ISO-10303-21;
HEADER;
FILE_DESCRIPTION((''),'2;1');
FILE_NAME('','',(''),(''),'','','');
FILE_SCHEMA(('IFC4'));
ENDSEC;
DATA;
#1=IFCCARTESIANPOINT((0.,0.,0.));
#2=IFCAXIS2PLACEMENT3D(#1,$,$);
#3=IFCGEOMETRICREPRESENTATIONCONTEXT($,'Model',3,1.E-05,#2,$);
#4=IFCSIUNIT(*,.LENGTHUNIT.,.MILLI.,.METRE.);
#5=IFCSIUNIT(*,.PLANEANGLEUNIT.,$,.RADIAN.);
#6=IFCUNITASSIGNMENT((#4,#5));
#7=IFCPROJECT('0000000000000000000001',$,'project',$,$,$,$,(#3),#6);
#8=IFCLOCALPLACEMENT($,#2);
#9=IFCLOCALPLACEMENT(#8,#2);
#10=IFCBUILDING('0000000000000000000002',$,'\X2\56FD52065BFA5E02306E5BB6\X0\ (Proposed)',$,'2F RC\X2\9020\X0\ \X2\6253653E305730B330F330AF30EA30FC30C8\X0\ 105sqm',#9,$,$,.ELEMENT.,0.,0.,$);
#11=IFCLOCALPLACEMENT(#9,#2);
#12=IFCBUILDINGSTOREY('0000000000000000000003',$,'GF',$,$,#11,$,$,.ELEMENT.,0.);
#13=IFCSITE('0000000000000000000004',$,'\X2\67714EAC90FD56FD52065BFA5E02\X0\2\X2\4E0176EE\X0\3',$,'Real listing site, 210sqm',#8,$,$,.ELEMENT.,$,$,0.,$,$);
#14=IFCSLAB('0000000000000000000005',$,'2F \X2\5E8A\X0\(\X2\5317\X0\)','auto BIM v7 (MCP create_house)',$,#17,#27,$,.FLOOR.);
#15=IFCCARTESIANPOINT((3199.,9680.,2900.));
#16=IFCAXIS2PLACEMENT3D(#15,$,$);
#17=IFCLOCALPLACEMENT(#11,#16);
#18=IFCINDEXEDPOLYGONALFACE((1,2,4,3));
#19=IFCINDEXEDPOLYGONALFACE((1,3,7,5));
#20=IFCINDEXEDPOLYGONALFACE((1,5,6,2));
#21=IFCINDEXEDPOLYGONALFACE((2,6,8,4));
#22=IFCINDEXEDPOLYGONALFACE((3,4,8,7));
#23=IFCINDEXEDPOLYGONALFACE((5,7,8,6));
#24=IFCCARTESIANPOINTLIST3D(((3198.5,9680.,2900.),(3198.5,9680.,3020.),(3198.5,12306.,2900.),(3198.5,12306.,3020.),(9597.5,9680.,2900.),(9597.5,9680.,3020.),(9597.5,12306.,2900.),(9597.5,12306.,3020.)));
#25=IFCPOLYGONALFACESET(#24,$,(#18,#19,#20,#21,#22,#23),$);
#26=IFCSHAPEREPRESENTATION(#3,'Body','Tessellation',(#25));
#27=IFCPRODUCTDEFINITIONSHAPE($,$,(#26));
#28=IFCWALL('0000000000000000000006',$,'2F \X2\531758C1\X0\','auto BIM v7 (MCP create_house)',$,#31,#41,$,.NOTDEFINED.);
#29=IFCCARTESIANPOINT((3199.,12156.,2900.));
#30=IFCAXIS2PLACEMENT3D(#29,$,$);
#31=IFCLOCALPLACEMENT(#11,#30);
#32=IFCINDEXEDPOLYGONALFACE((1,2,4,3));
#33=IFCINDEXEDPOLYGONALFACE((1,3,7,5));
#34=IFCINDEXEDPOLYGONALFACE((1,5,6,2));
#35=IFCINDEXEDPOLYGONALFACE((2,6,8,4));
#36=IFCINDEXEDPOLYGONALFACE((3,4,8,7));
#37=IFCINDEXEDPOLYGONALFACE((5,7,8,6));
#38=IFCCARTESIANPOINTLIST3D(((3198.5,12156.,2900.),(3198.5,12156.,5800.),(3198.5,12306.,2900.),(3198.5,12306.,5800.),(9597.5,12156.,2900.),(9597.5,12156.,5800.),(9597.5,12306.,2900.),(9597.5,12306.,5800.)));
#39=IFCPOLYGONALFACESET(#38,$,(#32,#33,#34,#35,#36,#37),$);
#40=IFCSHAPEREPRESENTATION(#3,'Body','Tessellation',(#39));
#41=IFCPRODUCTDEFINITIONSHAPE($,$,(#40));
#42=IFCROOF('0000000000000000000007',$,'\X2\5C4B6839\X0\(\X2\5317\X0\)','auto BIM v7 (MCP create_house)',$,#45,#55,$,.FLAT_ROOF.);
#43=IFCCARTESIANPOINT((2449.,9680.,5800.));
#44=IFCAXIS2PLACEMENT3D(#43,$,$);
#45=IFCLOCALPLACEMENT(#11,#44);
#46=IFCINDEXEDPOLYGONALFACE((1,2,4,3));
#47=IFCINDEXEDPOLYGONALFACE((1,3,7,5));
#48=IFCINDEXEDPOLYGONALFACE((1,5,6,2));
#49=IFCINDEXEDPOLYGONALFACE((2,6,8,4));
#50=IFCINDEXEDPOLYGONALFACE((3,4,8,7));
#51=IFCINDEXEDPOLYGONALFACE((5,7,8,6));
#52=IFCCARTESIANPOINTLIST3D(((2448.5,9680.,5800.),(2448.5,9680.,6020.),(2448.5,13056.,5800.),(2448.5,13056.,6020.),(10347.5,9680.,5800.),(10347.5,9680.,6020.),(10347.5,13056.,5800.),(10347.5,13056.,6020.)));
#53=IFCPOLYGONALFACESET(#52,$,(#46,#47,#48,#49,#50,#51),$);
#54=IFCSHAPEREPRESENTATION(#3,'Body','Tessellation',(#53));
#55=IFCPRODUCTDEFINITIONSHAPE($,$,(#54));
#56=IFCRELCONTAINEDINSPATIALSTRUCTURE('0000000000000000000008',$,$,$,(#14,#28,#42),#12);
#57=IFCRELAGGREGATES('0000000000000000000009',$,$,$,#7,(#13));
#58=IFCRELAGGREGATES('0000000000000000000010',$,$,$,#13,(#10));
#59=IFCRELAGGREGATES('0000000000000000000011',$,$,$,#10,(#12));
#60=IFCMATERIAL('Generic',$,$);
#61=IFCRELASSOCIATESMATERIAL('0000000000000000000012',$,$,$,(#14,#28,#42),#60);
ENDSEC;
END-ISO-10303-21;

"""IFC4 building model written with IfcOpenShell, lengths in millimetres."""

from ifc_helpers import new_model, si_unit, frame, frame_2d, origin, place, context, project, spatial, rectangle, extrude, material, element, save


model = new_model("IFC4")

# Units and contexts
model_context = context("Model", 3, precision=1e-05, world=origin())
ifc_project = project(units=[si_unit("LENGTHUNIT", "METRE", prefix="MILLI"), si_unit("PLANEANGLEUNIT", "RADIAN")], contexts=[model_context])

# Site, building, storey
site_placement = place(None, origin())
site = spatial("IfcSite", under=ifc_project, at=site_placement, Name="東京都国分寺市2丁目3", ObjectType="Real listing site, 210sqm", CompositionType="ELEMENT", RefElevation=0.0)
building_placement = place(site_placement, origin())
building = spatial("IfcBuilding", under=site, at=building_placement, Name="国分寺市の家 (Proposed)", ObjectType="2F RC造 打放しコンクリート 105sqm", CompositionType="ELEMENT", ElevationOfRefHeight=0.0, ElevationOfTerrain=0.0)
storey_placement = place(building_placement, origin())
storey = spatial("IfcBuildingStorey", under=building, at=storey_placement, Name="GF", CompositionType="ELEMENT", Elevation=0.0)

# Slab
ifc_material = material(Name="Generic")
slab_1_placement = place(storey_placement, frame((3199.0, 9680.0, 2900.0)))
element("IfcSlab", 1, at=slab_1_placement, inside=storey, material=ifc_material, Name="2F 床(北)", Description="auto BIM v7 (MCP create_house)", PredefinedType="FLOOR", context=model_context, shape_type="SweptSolid", body=[
    extrude(rectangle(XDim=6399.0, YDim=2626.0, at=frame_2d((3199.0, 1313.0))), frame((3199.0, 9680.0, 2900.0)), (0.0, 0.0, 1.0), 120.0),
])

# Wall
wall_1_placement = place(storey_placement, frame((3199.0, 12156.0, 2900.0)))
element("IfcWall", 2, at=wall_1_placement, inside=storey, material=ifc_material, Name="2F 北壁", Description="auto BIM v7 (MCP create_house)", PredefinedType="NOTDEFINED", context=model_context, shape_type="SweptSolid", body=[
    extrude(rectangle(XDim=6399.0, YDim=150.0, at=frame_2d((3199.0, 75.0))), frame((3199.0, 12156.0, 2900.0)), (0.0, 0.0, 1.0), 2900.0),
])

# Roof
roof_1_placement = place(storey_placement, frame((2449.0, 9680.0, 5800.0)))
element("IfcRoof", 3, at=roof_1_placement, inside=storey, material=ifc_material, Name="屋根(北)", Description="auto BIM v7 (MCP create_house)", PredefinedType="FLAT_ROOF", context=model_context, shape_type="SweptSolid", body=[
    extrude(rectangle(XDim=7899.0, YDim=3376.0, at=frame_2d((3949.0, 1688.0))), frame((2449.0, 9680.0, 5800.0)), (0.0, 0.0, 1.0), 220.0),
])

save(model, "model.ifc")
